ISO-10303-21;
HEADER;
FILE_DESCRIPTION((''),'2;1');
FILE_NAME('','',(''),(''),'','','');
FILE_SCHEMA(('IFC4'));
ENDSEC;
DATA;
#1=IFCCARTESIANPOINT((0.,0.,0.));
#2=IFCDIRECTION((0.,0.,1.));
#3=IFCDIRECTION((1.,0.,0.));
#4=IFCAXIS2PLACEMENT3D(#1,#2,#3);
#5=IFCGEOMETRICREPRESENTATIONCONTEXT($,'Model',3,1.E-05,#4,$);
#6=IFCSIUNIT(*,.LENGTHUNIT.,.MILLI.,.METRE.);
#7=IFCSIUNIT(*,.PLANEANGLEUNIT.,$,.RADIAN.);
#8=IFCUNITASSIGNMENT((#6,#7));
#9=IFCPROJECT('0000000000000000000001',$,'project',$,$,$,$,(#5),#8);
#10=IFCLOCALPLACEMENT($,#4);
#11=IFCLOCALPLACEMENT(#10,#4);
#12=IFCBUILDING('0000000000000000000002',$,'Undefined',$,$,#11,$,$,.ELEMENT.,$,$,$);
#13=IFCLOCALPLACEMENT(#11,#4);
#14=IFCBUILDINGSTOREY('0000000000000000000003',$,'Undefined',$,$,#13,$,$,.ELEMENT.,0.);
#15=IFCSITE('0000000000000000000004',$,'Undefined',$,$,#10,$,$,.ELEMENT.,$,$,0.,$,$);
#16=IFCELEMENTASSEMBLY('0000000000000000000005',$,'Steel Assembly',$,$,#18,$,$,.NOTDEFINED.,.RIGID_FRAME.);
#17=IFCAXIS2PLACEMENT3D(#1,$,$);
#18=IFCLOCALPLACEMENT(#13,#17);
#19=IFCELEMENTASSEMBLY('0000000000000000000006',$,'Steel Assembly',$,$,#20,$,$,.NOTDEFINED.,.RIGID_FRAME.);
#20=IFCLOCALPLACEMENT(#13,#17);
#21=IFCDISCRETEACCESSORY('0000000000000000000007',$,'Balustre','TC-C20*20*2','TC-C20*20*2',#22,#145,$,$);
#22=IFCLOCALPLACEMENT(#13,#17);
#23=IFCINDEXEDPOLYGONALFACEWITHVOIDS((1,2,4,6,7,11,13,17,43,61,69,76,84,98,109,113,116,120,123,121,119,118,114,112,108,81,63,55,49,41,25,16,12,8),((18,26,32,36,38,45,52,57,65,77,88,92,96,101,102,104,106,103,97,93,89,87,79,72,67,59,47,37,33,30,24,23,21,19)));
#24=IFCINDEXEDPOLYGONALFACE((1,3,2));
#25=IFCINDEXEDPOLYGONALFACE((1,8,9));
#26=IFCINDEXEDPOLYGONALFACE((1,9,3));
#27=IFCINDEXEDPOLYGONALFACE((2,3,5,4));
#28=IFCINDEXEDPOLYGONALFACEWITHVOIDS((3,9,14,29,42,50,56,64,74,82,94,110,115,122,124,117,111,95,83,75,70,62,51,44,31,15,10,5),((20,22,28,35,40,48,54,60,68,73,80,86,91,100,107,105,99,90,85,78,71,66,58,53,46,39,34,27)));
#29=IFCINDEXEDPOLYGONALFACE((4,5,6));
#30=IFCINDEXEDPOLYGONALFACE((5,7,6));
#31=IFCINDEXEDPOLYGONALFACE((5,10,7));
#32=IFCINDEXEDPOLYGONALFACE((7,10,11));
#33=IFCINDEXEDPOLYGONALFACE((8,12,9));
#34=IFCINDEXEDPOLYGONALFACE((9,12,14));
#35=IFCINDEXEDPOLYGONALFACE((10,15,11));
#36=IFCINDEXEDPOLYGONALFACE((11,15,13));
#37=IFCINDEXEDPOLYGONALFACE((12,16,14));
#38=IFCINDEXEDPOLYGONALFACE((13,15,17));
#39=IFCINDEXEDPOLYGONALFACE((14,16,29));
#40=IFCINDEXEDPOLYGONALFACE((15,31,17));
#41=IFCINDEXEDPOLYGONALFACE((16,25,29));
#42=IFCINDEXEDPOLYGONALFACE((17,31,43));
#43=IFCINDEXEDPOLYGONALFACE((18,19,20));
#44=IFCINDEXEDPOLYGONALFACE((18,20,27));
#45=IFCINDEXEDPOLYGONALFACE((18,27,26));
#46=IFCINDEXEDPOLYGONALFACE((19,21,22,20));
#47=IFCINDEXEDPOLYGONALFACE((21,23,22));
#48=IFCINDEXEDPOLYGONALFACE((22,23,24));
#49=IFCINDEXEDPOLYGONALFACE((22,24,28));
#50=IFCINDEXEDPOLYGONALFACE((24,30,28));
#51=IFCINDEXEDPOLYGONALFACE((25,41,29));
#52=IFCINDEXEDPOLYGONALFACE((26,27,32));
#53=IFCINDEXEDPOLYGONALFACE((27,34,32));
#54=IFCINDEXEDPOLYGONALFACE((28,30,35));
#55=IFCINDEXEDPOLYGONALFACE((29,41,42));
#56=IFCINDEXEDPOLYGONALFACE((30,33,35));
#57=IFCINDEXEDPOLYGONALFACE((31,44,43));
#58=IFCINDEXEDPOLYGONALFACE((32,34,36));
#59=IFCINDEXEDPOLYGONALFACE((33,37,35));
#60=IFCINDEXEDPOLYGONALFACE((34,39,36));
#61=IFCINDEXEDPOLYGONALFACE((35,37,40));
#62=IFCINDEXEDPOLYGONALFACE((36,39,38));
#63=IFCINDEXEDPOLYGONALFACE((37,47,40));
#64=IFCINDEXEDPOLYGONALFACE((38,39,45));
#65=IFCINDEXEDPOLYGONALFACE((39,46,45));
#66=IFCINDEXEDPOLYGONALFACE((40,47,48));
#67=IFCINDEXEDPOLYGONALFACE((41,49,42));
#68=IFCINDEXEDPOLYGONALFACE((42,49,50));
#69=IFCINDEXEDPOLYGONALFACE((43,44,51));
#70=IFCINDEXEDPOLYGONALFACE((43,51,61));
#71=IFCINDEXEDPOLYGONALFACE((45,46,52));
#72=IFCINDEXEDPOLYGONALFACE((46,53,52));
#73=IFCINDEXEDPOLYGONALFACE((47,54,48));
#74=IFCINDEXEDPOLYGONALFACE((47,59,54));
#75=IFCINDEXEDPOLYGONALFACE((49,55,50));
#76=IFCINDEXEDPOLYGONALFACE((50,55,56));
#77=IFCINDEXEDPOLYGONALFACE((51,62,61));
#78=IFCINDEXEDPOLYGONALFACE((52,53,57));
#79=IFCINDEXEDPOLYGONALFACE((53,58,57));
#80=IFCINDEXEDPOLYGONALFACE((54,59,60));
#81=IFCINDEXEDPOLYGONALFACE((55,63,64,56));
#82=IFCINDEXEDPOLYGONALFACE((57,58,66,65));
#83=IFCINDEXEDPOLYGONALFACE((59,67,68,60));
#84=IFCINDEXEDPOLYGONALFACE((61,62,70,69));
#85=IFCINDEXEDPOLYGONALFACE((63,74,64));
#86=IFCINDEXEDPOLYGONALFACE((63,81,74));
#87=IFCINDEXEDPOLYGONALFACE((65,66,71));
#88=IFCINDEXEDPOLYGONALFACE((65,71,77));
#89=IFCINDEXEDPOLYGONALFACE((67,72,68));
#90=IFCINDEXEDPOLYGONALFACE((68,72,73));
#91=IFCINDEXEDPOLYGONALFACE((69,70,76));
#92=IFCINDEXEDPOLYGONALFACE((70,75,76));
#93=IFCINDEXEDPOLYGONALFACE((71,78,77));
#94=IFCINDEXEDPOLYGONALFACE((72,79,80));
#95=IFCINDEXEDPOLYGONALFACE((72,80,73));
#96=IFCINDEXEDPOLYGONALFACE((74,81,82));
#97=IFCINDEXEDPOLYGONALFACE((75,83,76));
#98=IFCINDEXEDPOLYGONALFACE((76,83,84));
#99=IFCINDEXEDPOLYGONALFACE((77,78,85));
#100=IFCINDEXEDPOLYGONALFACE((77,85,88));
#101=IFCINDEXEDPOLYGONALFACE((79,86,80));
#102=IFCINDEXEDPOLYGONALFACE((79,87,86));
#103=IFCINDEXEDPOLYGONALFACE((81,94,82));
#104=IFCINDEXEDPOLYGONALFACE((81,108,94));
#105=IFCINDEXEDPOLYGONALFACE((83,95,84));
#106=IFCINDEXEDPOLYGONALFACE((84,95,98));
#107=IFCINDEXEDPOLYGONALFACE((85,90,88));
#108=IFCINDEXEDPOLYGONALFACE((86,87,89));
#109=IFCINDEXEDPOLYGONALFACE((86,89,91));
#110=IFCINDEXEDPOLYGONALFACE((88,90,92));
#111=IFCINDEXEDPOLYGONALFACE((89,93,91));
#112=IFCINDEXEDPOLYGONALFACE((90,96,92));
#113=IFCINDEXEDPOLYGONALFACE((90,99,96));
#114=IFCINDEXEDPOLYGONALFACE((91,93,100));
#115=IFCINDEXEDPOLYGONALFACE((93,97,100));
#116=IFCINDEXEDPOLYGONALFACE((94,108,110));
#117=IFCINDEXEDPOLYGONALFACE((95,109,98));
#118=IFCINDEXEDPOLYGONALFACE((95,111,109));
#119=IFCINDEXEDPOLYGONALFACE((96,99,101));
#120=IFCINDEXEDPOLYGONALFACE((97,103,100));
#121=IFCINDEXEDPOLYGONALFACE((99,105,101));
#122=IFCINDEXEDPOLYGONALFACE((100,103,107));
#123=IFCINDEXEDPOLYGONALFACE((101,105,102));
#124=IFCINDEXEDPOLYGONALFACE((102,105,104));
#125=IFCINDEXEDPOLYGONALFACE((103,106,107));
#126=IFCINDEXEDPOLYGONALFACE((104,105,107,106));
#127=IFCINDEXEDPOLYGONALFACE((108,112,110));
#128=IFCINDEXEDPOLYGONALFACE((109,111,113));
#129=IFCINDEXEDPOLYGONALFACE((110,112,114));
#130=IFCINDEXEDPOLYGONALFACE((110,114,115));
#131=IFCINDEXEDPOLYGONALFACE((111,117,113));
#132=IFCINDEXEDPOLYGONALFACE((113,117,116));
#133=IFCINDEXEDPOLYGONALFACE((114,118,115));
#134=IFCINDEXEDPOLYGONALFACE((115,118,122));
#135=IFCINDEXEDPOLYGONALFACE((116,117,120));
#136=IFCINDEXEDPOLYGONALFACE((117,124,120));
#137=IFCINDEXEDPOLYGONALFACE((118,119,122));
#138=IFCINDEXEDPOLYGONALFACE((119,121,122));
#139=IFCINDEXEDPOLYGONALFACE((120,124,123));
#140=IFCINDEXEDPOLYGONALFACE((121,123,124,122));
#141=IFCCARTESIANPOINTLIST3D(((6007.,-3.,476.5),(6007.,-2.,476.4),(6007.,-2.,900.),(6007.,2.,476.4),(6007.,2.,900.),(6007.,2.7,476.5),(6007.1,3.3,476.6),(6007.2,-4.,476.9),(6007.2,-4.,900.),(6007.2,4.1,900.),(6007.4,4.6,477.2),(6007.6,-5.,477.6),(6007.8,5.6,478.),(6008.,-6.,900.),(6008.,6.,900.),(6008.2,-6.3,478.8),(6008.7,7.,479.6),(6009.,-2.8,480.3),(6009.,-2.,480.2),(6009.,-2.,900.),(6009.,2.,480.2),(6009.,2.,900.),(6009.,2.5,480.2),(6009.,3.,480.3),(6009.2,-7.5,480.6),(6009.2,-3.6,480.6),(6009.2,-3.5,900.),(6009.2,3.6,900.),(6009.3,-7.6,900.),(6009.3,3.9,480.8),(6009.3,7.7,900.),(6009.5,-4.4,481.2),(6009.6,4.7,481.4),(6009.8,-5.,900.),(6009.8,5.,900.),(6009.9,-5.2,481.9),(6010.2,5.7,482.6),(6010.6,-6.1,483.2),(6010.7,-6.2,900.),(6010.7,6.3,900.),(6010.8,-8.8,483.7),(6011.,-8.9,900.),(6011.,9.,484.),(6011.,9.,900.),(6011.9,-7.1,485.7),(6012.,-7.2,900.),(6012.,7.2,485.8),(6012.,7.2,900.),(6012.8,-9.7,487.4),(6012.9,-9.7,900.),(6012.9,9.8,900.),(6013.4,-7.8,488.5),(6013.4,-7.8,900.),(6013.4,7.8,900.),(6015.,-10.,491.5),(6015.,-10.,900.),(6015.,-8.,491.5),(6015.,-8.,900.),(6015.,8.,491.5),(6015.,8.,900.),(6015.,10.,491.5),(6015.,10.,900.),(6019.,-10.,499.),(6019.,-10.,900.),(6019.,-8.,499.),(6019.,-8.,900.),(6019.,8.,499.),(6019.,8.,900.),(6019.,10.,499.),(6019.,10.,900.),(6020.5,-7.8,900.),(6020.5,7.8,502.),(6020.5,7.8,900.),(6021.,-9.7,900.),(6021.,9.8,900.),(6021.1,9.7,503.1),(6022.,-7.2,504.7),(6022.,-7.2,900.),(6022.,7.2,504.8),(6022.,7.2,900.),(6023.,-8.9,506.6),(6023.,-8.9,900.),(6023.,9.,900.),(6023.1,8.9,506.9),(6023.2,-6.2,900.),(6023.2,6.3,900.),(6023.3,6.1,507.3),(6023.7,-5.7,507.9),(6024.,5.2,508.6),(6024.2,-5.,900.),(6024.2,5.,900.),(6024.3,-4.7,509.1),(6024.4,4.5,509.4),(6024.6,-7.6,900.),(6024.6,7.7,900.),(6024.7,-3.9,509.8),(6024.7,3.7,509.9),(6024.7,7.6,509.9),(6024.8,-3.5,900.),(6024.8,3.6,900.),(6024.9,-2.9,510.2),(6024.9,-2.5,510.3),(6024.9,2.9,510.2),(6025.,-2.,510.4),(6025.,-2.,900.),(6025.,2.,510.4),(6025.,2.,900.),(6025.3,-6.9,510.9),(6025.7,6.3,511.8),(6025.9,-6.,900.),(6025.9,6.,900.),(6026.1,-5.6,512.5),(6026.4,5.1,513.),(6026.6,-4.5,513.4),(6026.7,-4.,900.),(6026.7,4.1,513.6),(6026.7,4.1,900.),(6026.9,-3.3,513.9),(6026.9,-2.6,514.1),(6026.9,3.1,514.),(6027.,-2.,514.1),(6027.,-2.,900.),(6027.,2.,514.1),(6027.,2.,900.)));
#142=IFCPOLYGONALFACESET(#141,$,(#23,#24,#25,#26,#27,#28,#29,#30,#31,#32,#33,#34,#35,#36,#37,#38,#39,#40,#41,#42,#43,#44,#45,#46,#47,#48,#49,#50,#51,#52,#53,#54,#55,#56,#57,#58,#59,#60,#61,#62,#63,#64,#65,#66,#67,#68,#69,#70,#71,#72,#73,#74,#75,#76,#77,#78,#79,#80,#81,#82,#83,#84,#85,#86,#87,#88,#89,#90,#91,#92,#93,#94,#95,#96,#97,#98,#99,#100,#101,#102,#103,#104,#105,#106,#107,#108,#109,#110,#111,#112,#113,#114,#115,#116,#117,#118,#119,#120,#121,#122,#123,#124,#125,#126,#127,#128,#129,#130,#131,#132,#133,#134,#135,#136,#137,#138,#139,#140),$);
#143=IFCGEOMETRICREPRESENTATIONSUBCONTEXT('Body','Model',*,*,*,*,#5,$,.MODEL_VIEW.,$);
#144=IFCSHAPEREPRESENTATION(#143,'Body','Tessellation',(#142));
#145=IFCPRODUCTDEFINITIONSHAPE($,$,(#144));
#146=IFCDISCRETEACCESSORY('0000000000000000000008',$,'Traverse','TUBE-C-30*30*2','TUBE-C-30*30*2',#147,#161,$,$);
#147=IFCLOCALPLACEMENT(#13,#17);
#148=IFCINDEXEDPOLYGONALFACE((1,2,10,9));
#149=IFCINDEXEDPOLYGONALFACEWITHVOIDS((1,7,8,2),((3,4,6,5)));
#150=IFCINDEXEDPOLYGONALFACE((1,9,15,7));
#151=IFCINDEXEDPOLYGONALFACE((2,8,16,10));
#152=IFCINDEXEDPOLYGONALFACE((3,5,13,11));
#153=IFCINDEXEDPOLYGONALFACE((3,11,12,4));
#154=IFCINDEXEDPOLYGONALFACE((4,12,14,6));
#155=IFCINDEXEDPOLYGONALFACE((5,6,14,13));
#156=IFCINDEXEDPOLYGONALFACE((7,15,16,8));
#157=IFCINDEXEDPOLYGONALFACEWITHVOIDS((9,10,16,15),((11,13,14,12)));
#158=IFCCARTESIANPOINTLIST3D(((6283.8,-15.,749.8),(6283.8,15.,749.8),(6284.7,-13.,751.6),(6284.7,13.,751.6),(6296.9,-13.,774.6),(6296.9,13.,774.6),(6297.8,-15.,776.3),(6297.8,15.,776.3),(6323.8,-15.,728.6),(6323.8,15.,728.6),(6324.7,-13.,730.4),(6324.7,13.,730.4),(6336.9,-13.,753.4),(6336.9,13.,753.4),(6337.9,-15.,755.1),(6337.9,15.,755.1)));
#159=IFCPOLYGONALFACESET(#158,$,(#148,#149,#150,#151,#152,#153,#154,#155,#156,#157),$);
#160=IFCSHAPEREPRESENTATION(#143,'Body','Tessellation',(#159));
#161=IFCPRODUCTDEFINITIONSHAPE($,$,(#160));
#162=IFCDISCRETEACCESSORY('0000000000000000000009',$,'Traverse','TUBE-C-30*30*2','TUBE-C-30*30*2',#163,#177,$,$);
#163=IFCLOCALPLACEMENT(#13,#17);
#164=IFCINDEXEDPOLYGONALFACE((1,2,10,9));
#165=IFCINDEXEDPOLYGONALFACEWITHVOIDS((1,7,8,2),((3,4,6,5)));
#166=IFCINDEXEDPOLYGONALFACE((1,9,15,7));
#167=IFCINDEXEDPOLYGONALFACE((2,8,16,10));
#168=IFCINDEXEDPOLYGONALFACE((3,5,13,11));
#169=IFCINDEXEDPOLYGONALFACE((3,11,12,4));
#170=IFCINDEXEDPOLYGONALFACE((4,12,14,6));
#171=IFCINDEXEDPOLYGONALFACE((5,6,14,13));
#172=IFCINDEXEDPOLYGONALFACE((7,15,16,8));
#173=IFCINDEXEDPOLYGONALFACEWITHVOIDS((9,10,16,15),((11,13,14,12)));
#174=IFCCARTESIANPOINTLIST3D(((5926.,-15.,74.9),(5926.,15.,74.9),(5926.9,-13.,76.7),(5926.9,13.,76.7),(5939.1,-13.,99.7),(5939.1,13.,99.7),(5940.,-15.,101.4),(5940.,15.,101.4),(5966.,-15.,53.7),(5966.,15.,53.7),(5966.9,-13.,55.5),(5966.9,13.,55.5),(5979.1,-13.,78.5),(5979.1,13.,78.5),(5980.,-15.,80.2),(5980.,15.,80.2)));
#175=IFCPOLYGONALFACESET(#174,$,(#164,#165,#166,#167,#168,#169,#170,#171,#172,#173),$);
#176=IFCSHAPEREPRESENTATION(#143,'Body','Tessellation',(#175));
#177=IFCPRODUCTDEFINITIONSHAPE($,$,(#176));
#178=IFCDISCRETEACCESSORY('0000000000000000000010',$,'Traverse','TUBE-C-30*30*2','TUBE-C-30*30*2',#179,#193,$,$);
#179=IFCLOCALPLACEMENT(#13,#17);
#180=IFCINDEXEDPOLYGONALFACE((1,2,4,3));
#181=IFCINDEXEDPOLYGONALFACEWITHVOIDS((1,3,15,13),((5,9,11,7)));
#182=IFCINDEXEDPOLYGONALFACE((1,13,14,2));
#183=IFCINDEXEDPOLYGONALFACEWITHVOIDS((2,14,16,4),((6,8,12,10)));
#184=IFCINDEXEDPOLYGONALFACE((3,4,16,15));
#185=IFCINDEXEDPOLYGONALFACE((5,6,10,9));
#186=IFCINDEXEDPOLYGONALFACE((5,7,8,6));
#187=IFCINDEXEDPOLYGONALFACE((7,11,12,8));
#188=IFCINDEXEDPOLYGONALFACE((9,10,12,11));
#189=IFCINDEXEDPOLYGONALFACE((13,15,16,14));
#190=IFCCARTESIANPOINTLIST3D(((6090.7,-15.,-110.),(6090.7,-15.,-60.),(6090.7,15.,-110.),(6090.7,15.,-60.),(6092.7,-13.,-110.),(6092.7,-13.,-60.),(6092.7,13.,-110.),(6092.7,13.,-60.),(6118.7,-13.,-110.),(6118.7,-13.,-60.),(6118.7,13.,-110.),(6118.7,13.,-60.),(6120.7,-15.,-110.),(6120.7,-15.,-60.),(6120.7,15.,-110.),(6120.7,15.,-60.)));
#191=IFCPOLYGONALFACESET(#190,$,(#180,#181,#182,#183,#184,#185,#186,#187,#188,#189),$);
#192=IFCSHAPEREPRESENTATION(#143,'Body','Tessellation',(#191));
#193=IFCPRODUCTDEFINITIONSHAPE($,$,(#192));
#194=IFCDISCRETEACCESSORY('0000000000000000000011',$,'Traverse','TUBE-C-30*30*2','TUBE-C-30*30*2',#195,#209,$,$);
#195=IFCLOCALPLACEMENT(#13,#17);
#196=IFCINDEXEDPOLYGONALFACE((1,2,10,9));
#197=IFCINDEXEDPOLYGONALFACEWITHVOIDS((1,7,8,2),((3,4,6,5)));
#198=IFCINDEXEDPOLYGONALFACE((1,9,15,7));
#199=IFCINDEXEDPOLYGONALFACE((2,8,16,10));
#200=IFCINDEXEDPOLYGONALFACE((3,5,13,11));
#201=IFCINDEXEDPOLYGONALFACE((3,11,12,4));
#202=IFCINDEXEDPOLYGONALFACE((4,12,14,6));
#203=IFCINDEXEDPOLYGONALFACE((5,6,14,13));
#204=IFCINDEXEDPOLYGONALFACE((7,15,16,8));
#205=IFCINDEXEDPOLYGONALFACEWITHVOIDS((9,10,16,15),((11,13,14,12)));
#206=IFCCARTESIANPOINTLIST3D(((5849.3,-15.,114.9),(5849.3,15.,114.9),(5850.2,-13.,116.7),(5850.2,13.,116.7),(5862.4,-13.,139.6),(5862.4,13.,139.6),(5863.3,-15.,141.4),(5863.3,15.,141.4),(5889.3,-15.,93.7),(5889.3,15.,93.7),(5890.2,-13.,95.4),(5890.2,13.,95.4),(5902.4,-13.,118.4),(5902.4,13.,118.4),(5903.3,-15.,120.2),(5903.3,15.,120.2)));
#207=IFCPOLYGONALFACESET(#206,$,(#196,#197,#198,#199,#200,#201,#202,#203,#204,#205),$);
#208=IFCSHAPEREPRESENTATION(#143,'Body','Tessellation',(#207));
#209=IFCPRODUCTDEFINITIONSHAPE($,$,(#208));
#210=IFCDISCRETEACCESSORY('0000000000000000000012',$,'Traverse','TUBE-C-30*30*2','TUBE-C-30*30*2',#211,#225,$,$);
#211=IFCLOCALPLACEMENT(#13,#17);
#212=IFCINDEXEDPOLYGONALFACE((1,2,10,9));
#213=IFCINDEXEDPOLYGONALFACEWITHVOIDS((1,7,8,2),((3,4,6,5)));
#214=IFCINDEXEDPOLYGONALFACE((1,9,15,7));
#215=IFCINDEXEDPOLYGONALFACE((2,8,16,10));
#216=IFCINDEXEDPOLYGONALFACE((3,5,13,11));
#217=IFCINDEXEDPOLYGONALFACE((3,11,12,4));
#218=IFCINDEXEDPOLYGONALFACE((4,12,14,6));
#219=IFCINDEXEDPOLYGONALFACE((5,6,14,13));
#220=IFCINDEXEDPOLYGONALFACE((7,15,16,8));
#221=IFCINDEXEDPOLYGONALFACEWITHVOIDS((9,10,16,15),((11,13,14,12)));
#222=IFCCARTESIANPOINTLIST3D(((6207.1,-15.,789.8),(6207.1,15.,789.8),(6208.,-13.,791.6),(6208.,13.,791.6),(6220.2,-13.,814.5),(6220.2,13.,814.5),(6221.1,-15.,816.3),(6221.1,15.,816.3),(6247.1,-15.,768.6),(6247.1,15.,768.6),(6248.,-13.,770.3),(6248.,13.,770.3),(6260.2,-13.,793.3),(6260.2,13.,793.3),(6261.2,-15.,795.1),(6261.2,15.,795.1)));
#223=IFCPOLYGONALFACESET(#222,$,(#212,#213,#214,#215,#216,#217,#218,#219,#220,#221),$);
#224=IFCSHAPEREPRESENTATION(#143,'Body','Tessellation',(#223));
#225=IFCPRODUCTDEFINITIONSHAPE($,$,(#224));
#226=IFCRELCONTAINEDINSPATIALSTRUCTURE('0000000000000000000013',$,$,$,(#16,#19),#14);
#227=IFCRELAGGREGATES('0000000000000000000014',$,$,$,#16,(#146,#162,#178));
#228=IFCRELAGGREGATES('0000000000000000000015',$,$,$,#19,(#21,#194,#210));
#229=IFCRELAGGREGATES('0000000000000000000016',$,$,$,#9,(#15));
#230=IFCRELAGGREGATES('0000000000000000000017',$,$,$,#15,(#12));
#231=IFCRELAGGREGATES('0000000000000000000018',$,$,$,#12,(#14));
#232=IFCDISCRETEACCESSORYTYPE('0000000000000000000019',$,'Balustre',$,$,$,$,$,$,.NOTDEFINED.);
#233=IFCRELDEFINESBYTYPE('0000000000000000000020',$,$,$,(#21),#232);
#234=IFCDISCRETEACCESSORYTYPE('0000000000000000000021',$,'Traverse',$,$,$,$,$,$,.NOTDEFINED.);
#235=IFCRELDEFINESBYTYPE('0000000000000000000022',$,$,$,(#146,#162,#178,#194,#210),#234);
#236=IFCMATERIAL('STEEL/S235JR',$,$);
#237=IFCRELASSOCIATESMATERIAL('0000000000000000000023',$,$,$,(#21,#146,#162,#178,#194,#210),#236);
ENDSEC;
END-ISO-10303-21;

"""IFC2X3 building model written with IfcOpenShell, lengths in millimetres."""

from ifc_helpers import new_model, si_unit, frame, origin_with_axes, origin_2d_with_axis, place, context, subcontext, project, spatial, hollow_rectangle, extrude, clip, halfspace, material, type_object, element, aggregate, save


model = new_model("IFC2X3")

# Units and contexts
model_context = context("Model", 3, precision=1e-05, world=origin_with_axes())
body_context = subcontext(model_context, "Body", "Model", "MODEL_VIEW")
ifc_project = project(units=[si_unit("LENGTHUNIT", "METRE", prefix="MILLI"), si_unit("PLANEANGLEUNIT", "RADIAN")], contexts=[model_context])

# Site, building, storey
site_placement = place(None, origin_with_axes())
site = spatial("IfcSite", under=ifc_project, at=site_placement, Name="Undefined", CompositionType="ELEMENT", RefElevation=0.0)
building_placement = place(site_placement, origin_with_axes())
building = spatial("IfcBuilding", under=site, at=building_placement, Name="Undefined", CompositionType="ELEMENT")
storey_placement = place(building_placement, origin_with_axes())
storey = spatial("IfcBuildingStorey", under=building, at=storey_placement, Name="Undefined", CompositionType="ELEMENT", Elevation=0.0)

# Element assemblies
assembly_1_placement = place(storey_placement, origin_with_axes())
assembly_1 = element("IfcElementAssembly", 1, at=assembly_1_placement, inside=storey, Name="Steel Assembly", AssemblyPlace="NOTDEFINED", PredefinedType="RIGID_FRAME")
ifc_material = material(Name="STEEL/S235JR")
assembly_2_placement = place(storey_placement, origin_with_axes())
assembly_2 = element("IfcElementAssembly", 2, at=assembly_2_placement, inside=storey, Name="Steel Assembly", AssemblyPlace="NOTDEFINED", PredefinedType="RIGID_FRAME")

# Discrete accessories
discrete_accessory_type_1 = type_object("IfcDiscreteAccessoryType", Name="Balustre")
discrete_accessory_1_placement = place(assembly_2_placement, frame((6017.0, 0.0, 900.0), z_axis=(-0.000011, 1.0, 0.0), x_axis=(0.0, 0.0, -1.0)))
discrete_accessory_1 = element("IfcDiscreteAccessory", 3, at=discrete_accessory_1_placement, type_object=discrete_accessory_type_1, material=ifc_material, Name="Balustre", Description="TC-C20*20*2", ObjectType="TC-C20*20*2", context=body_context, shape_type="Clipping", body=[
    clip(extrude(hollow_rectangle(XDim=20.0, YDim=20.0, WallThickness=2.0, InnerFilletRadius=6.0, OuterFilletRadius=8.0, at=origin_2d_with_axis()), frame((423.8, 0.0, 0.0), z_axis=(-1.0, 0.0, 0.0), x_axis=(0.0, -1.0, 0.0)), (0.0, 0.0, 1.0), 423.8), halfspace(frame((429.9, 13.3, 0.0), z_axis=(-0.46842, 0.883506, 0.000005), x_axis=(0.0, -0.000005, 1.0)), True)),
])
discrete_accessory_type_2 = type_object("IfcDiscreteAccessoryType", Name="Traverse")
discrete_accessory_2_placement = place(assembly_1_placement, frame((6330.8, 0.0, 741.9), z_axis=(-0.000011, 1.0, 0.0), x_axis=(-0.883506, -0.00001, 0.46842)))
discrete_accessory_2 = element("IfcDiscreteAccessory", 4, at=discrete_accessory_2_placement, type_object=discrete_accessory_type_2, material=ifc_material, Name="Traverse", Description="TUBE-C-30*30*2", ObjectType="TUBE-C-30*30*2", context=body_context, shape_type="SweptSolid", body=[
    extrude(hollow_rectangle(XDim=30.0, YDim=30.0, WallThickness=2.0, at=origin_2d_with_axis()), frame((45.3, 0.0, 0.0), z_axis=(-1.0, 0.0, 0.0), x_axis=(0.0, -1.0, 0.0)), (0.0, 0.0, 1.0), 45.3),
])
discrete_accessory_3_placement = place(assembly_1_placement, frame((5973.0, 0.0, 67.0), z_axis=(-0.000011, 1.0, 0.0), x_axis=(-0.883506, -0.00001, 0.46842)))
discrete_accessory_3 = element("IfcDiscreteAccessory", 5, at=discrete_accessory_3_placement, type_object=discrete_accessory_type_2, material=ifc_material, Name="Traverse", Description="TUBE-C-30*30*2", ObjectType="TUBE-C-30*30*2", context=body_context, shape_type="SweptSolid", body=[
    extrude(hollow_rectangle(XDim=30.0, YDim=30.0, WallThickness=2.0, at=origin_2d_with_axis()), frame((45.3, 0.0, 0.0), z_axis=(-1.0, 0.0, 0.0), x_axis=(0.0, -1.0, 0.0)), (0.0, 0.0, 1.0), 45.3),
])
discrete_accessory_4_placement = place(assembly_1_placement, frame((6105.7, 0.0, -60.0), z_axis=(-0.000011, 1.0, 0.0), x_axis=(0.0, 0.0, -1.0)))
discrete_accessory_4 = element("IfcDiscreteAccessory", 6, at=discrete_accessory_4_placement, type_object=discrete_accessory_type_2, material=ifc_material, Name="Traverse", Description="TUBE-C-30*30*2", ObjectType="TUBE-C-30*30*2", context=body_context, shape_type="SweptSolid", body=[
    extrude(hollow_rectangle(XDim=30.0, YDim=30.0, WallThickness=2.0, at=origin_2d_with_axis()), frame((50.0, 0.0, 0.0), z_axis=(-1.0, 0.0, 0.0), x_axis=(0.0, -1.0, 0.0)), (0.0, 0.0, 1.0), 50.0),
])
aggregate(assembly_1, [discrete_accessory_2, discrete_accessory_3, discrete_accessory_4])
discrete_accessory_5_placement = place(assembly_2_placement, frame((5856.3, 0.0, 128.2), z_axis=(0.0, 1.0, 0.0), x_axis=(0.883506, 0.0, -0.46842)))
discrete_accessory_5 = element("IfcDiscreteAccessory", 7, at=discrete_accessory_5_placement, type_object=discrete_accessory_type_2, material=ifc_material, Name="Traverse", Description="TUBE-C-30*30*2", ObjectType="TUBE-C-30*30*2", context=body_context, shape_type="SweptSolid", body=[
    extrude(hollow_rectangle(XDim=30.0, YDim=30.0, WallThickness=2.0, at=origin_2d_with_axis()), frame((45.3, 0.0, 0.0), z_axis=(-1.0, 0.0, 0.0), x_axis=(0.0, -1.0, 0.0)), (0.0, 0.0, 1.0), 45.3),
])
discrete_accessory_6_placement = place(assembly_2_placement, frame((6214.1, 0.0, 803.0), z_axis=(0.0, 1.0, 0.0), x_axis=(0.883506, 0.0, -0.46842)))
discrete_accessory_6 = element("IfcDiscreteAccessory", 8, at=discrete_accessory_6_placement, type_object=discrete_accessory_type_2, material=ifc_material, Name="Traverse", Description="TUBE-C-30*30*2", ObjectType="TUBE-C-30*30*2", context=body_context, shape_type="SweptSolid", body=[
    extrude(hollow_rectangle(XDim=30.0, YDim=30.0, WallThickness=2.0, at=origin_2d_with_axis()), frame((45.3, 0.0, 0.0), z_axis=(-1.0, 0.0, 0.0), x_axis=(0.0, -1.0, 0.0)), (0.0, 0.0, 1.0), 45.3),
])
aggregate(assembly_2, [discrete_accessory_1, discrete_accessory_5, discrete_accessory_6])

save(model, "model.ifc")
